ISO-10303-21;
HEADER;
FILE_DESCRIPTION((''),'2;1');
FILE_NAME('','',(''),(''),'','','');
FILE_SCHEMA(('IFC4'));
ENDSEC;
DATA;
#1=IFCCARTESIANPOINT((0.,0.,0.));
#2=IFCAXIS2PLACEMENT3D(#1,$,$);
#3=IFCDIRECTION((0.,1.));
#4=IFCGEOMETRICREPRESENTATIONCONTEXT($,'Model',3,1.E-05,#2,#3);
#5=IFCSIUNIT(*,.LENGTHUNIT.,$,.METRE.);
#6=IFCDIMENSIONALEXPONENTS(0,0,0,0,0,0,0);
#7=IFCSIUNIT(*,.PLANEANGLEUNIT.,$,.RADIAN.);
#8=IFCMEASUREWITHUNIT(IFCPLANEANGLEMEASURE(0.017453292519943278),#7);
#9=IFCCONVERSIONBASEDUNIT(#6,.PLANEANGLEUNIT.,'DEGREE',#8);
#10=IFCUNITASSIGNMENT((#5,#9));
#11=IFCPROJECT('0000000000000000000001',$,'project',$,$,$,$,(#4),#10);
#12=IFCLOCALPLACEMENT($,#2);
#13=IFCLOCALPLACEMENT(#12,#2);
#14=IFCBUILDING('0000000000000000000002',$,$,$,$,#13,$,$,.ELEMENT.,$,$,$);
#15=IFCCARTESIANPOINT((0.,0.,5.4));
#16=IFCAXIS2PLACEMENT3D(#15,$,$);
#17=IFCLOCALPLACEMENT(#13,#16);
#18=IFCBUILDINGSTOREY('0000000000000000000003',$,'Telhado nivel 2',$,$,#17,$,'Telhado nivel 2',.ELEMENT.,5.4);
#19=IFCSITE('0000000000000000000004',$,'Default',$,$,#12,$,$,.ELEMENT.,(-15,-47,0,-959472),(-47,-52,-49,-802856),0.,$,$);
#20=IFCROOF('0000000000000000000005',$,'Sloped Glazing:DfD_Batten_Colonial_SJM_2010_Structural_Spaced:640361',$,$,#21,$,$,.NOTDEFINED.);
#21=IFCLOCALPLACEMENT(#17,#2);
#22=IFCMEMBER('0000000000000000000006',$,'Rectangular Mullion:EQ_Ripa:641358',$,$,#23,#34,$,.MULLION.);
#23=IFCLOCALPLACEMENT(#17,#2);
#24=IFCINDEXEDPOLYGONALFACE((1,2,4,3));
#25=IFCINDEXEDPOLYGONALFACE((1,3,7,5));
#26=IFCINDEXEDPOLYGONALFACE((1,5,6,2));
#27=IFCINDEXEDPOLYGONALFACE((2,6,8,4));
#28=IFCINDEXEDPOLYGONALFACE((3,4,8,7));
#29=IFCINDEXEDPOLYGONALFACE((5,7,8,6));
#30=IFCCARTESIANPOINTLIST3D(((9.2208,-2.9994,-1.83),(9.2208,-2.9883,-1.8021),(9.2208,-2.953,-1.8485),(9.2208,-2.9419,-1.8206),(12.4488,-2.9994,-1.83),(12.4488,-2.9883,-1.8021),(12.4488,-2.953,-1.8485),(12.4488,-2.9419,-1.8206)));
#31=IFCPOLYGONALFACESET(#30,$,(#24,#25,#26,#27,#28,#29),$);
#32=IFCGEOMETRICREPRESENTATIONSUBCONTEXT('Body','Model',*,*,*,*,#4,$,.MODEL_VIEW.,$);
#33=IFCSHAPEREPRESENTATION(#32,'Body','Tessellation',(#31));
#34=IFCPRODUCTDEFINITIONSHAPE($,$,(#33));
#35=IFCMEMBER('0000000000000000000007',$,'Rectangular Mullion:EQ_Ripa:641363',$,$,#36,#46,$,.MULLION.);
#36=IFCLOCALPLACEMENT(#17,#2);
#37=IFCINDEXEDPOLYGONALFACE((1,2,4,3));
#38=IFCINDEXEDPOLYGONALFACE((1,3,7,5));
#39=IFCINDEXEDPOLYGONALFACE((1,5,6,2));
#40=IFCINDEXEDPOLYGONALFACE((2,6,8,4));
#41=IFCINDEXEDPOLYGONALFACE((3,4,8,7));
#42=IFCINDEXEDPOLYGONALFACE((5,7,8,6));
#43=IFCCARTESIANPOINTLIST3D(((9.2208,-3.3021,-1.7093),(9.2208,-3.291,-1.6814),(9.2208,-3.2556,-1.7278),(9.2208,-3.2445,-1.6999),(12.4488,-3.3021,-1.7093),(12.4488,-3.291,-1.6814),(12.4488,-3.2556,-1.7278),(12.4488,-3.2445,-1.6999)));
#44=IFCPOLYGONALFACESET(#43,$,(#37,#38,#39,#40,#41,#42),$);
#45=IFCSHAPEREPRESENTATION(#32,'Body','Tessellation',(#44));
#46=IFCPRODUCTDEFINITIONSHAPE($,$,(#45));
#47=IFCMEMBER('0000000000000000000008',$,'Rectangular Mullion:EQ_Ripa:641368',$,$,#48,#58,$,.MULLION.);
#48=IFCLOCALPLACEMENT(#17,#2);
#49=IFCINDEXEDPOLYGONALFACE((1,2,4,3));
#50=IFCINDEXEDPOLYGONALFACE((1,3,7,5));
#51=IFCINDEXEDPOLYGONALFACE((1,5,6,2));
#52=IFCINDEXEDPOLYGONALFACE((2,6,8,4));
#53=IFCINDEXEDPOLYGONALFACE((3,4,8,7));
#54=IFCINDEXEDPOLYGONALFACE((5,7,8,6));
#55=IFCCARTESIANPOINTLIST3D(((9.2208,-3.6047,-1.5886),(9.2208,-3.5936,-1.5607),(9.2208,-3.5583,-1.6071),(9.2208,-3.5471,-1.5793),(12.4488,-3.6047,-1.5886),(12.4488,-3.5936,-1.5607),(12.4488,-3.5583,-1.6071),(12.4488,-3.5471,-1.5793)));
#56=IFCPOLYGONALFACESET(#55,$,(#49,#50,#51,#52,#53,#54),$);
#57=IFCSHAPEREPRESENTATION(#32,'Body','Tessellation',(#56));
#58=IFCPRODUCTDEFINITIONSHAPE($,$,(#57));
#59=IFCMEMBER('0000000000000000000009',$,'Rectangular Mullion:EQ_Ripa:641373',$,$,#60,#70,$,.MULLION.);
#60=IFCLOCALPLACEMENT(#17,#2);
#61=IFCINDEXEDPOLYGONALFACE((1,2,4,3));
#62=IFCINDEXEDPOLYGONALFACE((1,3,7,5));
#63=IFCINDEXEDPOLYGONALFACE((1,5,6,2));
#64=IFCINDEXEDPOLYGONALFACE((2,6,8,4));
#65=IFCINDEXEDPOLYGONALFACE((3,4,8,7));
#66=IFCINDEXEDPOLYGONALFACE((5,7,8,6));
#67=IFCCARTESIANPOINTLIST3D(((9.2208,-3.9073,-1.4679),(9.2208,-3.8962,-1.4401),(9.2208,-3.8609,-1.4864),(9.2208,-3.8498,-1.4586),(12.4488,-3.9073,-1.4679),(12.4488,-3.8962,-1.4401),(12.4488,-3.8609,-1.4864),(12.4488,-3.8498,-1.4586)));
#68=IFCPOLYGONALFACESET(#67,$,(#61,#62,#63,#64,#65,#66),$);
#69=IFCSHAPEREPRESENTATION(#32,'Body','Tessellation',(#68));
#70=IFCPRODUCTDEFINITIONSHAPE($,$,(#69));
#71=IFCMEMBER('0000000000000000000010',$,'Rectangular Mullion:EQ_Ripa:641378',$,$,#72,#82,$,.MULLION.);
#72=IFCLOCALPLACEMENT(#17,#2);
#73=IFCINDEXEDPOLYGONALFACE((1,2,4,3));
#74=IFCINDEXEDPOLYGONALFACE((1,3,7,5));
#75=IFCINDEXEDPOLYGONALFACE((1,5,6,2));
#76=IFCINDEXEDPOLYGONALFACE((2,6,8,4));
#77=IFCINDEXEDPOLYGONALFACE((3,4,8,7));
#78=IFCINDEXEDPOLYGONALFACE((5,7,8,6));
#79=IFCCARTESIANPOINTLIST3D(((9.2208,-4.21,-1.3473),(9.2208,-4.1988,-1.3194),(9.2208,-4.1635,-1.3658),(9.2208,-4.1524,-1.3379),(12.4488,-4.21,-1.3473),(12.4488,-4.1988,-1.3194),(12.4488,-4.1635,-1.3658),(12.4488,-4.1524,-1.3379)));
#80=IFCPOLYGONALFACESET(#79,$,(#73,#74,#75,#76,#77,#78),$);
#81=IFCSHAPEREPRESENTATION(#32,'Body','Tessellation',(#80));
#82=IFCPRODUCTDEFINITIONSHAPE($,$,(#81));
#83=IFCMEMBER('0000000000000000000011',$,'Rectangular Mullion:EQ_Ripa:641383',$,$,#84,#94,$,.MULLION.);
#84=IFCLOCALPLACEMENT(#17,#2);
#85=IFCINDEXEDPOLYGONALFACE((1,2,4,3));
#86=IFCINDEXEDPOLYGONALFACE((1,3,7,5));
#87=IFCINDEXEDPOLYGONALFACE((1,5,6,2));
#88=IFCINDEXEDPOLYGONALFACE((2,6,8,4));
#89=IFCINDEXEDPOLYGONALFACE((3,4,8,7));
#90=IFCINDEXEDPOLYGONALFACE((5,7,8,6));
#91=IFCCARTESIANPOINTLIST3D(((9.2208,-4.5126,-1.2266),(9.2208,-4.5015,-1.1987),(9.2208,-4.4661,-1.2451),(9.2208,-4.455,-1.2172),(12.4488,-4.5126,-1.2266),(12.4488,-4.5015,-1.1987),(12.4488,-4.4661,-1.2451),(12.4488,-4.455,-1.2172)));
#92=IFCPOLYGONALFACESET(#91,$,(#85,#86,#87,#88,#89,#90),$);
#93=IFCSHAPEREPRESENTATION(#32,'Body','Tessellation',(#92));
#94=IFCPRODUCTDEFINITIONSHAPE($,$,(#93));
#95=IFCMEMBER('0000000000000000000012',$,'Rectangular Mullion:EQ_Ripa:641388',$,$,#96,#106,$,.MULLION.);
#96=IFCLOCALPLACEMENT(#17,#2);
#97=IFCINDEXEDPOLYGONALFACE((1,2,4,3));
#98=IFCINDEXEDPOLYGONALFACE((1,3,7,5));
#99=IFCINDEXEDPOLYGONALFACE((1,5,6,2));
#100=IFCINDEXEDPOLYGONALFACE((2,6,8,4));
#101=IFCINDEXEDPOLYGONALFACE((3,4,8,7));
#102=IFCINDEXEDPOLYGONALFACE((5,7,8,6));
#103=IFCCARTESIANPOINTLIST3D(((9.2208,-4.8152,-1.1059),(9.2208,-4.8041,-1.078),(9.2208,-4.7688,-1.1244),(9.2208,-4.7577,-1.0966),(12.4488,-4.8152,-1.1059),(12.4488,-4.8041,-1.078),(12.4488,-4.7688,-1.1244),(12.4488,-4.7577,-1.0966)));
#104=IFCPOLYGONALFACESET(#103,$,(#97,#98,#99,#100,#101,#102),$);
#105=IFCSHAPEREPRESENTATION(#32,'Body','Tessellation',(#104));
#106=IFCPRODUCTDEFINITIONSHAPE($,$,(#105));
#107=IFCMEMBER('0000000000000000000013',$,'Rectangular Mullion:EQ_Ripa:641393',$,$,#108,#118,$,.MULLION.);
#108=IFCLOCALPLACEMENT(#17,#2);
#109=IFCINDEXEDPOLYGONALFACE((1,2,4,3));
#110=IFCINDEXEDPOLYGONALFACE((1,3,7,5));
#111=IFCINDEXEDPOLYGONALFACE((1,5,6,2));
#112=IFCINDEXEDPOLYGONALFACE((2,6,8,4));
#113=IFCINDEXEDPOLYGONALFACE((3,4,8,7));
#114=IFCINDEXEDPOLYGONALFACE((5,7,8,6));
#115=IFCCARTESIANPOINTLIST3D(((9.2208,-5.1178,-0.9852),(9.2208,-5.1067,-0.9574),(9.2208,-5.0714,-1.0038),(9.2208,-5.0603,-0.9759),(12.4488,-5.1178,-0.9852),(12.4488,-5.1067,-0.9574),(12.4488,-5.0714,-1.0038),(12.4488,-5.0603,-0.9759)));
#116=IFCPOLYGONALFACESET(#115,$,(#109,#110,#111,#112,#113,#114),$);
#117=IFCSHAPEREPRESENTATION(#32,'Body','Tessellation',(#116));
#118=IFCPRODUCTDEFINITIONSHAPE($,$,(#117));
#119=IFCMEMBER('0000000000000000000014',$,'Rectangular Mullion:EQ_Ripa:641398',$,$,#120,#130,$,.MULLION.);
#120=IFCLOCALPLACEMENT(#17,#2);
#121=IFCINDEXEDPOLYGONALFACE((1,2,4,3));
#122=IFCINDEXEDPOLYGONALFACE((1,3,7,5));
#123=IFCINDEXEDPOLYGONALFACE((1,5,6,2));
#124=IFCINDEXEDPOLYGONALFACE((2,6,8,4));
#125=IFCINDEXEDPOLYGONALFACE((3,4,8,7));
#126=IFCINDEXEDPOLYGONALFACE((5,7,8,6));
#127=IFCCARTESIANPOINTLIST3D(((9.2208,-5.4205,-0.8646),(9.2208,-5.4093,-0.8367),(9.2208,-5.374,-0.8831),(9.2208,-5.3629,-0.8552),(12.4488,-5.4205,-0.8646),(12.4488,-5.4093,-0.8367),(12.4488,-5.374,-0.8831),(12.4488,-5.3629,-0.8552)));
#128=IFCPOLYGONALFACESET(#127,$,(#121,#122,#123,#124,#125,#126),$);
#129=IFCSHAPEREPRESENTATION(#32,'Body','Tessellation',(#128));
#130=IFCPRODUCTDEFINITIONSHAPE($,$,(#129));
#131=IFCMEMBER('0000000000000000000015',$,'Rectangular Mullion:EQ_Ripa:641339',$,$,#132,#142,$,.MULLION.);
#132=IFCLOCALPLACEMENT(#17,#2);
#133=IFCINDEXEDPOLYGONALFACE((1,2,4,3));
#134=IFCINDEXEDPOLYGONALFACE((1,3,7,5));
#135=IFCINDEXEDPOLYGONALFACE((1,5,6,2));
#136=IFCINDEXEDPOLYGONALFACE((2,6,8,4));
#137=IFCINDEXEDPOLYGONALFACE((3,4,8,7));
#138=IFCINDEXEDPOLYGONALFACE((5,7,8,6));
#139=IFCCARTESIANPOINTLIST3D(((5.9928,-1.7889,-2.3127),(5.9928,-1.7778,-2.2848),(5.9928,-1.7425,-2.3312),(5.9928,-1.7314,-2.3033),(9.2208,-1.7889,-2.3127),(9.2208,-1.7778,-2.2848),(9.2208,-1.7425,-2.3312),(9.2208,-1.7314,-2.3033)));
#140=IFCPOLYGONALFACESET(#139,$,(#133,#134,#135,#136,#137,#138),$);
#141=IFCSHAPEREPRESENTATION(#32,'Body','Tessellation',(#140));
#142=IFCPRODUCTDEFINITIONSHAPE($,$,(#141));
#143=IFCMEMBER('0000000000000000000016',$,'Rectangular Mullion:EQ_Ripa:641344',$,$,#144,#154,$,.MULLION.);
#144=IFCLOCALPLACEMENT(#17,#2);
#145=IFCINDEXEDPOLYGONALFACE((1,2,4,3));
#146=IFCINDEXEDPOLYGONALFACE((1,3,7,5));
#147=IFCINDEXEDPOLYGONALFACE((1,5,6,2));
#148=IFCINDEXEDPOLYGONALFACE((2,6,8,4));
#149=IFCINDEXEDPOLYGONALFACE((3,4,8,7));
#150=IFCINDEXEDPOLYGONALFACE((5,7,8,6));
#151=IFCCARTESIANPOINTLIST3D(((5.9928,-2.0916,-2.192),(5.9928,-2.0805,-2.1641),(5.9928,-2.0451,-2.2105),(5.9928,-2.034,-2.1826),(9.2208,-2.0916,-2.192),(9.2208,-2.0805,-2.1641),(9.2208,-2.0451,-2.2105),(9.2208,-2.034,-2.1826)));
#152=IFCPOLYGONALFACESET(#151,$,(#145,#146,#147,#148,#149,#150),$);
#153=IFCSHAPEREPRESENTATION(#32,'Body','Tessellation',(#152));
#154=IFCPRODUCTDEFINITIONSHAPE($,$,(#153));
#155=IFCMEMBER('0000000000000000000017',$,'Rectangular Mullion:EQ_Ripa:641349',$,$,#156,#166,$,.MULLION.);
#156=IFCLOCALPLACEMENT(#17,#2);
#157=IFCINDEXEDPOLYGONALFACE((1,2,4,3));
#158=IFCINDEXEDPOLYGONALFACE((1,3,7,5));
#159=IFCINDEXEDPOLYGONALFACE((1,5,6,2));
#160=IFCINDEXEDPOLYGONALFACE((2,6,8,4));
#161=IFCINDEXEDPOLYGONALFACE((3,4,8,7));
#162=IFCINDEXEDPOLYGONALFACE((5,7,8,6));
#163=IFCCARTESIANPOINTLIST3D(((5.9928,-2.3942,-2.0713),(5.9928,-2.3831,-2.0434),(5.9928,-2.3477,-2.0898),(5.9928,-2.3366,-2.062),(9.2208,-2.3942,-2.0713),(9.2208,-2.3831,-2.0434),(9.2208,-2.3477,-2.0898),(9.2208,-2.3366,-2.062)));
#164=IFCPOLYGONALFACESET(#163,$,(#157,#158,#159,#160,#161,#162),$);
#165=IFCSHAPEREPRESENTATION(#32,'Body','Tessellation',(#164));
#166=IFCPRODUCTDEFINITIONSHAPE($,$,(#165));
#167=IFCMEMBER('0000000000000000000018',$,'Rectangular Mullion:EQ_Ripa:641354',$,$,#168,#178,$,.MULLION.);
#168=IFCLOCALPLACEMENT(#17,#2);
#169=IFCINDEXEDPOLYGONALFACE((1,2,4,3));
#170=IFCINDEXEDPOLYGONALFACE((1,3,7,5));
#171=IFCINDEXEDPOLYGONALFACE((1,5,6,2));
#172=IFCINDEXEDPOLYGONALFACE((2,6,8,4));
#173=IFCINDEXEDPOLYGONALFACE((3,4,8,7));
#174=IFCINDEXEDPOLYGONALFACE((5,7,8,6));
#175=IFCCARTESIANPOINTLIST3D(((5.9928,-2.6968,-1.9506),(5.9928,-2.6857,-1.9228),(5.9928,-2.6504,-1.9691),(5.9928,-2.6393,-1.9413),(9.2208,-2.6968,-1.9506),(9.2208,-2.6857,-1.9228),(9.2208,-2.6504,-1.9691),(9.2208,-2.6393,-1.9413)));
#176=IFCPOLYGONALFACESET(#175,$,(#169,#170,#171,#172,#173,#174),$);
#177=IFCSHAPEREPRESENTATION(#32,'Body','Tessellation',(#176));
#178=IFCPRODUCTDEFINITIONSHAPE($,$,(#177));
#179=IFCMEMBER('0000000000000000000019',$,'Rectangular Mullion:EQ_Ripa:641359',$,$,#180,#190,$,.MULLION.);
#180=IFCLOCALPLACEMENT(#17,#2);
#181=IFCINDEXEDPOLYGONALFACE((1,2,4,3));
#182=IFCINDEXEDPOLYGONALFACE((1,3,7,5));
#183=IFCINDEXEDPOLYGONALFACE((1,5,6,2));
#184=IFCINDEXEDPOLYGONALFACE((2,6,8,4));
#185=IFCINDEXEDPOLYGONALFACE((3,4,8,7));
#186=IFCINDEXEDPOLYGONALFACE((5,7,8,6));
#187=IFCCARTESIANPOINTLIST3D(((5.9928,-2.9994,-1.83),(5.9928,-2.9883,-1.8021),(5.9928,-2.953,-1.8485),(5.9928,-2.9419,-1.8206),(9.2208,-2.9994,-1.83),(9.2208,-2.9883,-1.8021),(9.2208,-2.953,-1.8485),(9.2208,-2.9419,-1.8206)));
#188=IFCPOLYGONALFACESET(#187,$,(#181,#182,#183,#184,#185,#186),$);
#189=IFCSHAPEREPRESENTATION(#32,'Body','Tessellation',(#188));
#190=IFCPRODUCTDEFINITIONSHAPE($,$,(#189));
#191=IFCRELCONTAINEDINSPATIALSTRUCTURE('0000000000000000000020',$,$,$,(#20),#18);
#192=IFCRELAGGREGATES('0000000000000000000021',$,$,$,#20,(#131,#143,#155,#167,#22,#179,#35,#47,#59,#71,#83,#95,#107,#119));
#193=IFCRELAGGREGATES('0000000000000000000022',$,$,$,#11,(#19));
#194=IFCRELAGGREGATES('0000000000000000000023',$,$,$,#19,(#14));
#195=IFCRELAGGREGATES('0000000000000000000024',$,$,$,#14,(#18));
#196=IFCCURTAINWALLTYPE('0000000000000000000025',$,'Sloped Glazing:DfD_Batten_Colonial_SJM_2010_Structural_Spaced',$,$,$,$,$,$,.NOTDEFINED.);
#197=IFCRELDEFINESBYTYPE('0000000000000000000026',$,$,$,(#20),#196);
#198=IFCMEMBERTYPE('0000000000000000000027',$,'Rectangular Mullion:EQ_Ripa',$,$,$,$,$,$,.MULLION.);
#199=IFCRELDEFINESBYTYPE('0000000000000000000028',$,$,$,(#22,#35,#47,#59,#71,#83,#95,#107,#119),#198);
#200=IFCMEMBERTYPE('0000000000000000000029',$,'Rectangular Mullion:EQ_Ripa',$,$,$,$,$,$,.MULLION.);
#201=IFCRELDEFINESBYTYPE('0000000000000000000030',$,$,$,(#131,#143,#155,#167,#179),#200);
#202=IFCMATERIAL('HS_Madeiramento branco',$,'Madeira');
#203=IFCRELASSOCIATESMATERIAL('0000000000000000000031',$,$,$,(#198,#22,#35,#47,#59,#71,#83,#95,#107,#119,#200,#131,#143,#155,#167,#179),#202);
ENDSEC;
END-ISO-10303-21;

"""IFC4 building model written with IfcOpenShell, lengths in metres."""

from ifc_helpers import new_model, entity, si_unit, converted_unit, direction, frame, origin, place, context, subcontext, project, spatial, indexed_curve, outline, extrude, source, transform, mapped, material, type_object, type_shapes, element, aggregate, save


model = new_model("IFC4")

# Units and contexts
model_context = context("Model", 3, precision=1e-05, world=origin(), true_north=direction((0.0, 1.0)))
body_context = subcontext(model_context, "Body", "Model", "MODEL_VIEW")
ifc_project = project(units=[si_unit("LENGTHUNIT", "METRE"), converted_unit("PLANEANGLEUNIT", "DEGREE", entity("IfcPlaneAngleMeasure", 0.017453292519943278), si_unit("PLANEANGLEUNIT", "RADIAN"), dimensions=[0, 0, 0, 0, 0, 0, 0])], contexts=[model_context])

# Site, building, storey
site_placement = place(None, origin())
site = spatial("IfcSite", under=ifc_project, at=site_placement, Name="Default", CompositionType="ELEMENT", RefLatitude=(-15, -47, 0, -959472), RefLongitude=(-47, -52, -49, -802856), RefElevation=0.0)
building_placement = place(site_placement, origin())
building = spatial("IfcBuilding", under=site, at=building_placement, CompositionType="ELEMENT")
storey_placement = place(building_placement, frame((0.0, 0.0, 5.4)))
storey = spatial("IfcBuildingStorey", under=building, at=storey_placement, Name="Telhado nivel 2", LongName="Telhado nivel 2", CompositionType="ELEMENT", Elevation=5.4)

# Roof, members
ifc_material = material(Name="HS_Madeiramento branco", Category="Madeira")
curtain_wall_type_1 = type_object("IfcCurtainWallType", Name="Sloped Glazing:DfD_Batten_Colonial_SJM_2010_Structural_Spaced", PredefinedType="NOTDEFINED")
roof_1_placement = place(storey_placement, frame((0.0, 0.0, -5.4)))
roof_1 = element("IfcRoof", 1, at=roof_1_placement, inside=storey, type_object=curtain_wall_type_1, Name="Sloped Glazing:DfD_Batten_Colonial_SJM_2010_Structural_Spaced:640361", PredefinedType="NOTDEFINED")
member_type_1 = type_object("IfcMemberType", Name="Rectangular Mullion:EQ_Ripa", PredefinedType="MULLION", material=ifc_material)
shared_shape_1 = source(origin(), body_context, "Body", "SweptSolid", [
    extrude(outline(indexed_curve([(-0.025, -0.015), (0.025, -0.015), (0.025, 0.015), (-0.025, 0.015), (-0.025, -0.015)], self_intersect=False)), frame((0.0, 0.0, -3.228), z_axis=(0.0, 0.0, 1.0), x_axis=(-1.0, 0.0, 0.0)), (0.0, 0.0, 1.0), 3.228),
])
type_shapes(member_type_1, [shared_shape_1])
member_1_placement = place(roof_1_placement, frame((12.4488, -2.9707, 3.5747), z_axis=(1.0, 0.0, 0.0), x_axis=(0.0, -0.928874, 0.370395)))
member_1 = element("IfcMember", 2, at=member_1_placement, type_object=member_type_1, material=ifc_material, Name="Rectangular Mullion:EQ_Ripa:641358", PredefinedType="MULLION", context=body_context, shape_type="MappedRepresentation", body=[
    mapped(shared_shape_1, transform((0.0, 0.0, 0.0), scale=1.0)),
])
member_2_placement = place(roof_1_placement, frame((12.4488, -3.2733, 3.6954), z_axis=(1.0, 0.0, 0.0), x_axis=(0.0, -0.928874, 0.370395)))
member_2 = element("IfcMember", 3, at=member_2_placement, type_object=member_type_1, material=ifc_material, Name="Rectangular Mullion:EQ_Ripa:641363", PredefinedType="MULLION", context=body_context, shape_type="MappedRepresentation", body=[
    mapped(shared_shape_1, transform((0.0, 0.0, 0.0), scale=1.0)),
])
member_3_placement = place(roof_1_placement, frame((12.4488, -3.5759, 3.8161), z_axis=(1.0, 0.0, 0.0), x_axis=(0.0, -0.928874, 0.370395)))
member_3 = element("IfcMember", 4, at=member_3_placement, type_object=member_type_1, material=ifc_material, Name="Rectangular Mullion:EQ_Ripa:641368", PredefinedType="MULLION", context=body_context, shape_type="MappedRepresentation", body=[
    mapped(shared_shape_1, transform((0.0, 0.0, 0.0), scale=1.0)),
])
member_4_placement = place(roof_1_placement, frame((12.4488, -3.8785, 3.9367), z_axis=(1.0, 0.0, 0.0), x_axis=(0.0, -0.928874, 0.370395)))
member_4 = element("IfcMember", 5, at=member_4_placement, type_object=member_type_1, material=ifc_material, Name="Rectangular Mullion:EQ_Ripa:641373", PredefinedType="MULLION", context=body_context, shape_type="MappedRepresentation", body=[
    mapped(shared_shape_1, transform((0.0, 0.0, 0.0), scale=1.0)),
])
member_5_placement = place(roof_1_placement, frame((12.4488, -4.1812, 4.0574), z_axis=(1.0, 0.0, 0.0), x_axis=(0.0, -0.928874, 0.370395)))
member_5 = element("IfcMember", 6, at=member_5_placement, type_object=member_type_1, material=ifc_material, Name="Rectangular Mullion:EQ_Ripa:641378", PredefinedType="MULLION", context=body_context, shape_type="MappedRepresentation", body=[
    mapped(shared_shape_1, transform((0.0, 0.0, 0.0), scale=1.0)),
])
member_6_placement = place(roof_1_placement, frame((12.4488, -4.4838, 4.1781), z_axis=(1.0, 0.0, 0.0), x_axis=(0.0, -0.928874, 0.370395)))
member_6 = element("IfcMember", 7, at=member_6_placement, type_object=member_type_1, material=ifc_material, Name="Rectangular Mullion:EQ_Ripa:641383", PredefinedType="MULLION", context=body_context, shape_type="MappedRepresentation", body=[
    mapped(shared_shape_1, transform((0.0, 0.0, 0.0), scale=1.0)),
])
member_7_placement = place(roof_1_placement, frame((12.4488, -4.7864, 4.2988), z_axis=(1.0, 0.0, 0.0), x_axis=(0.0, -0.928874, 0.370395)))
member_7 = element("IfcMember", 8, at=member_7_placement, type_object=member_type_1, material=ifc_material, Name="Rectangular Mullion:EQ_Ripa:641388", PredefinedType="MULLION", context=body_context, shape_type="MappedRepresentation", body=[
    mapped(shared_shape_1, transform((0.0, 0.0, 0.0), scale=1.0)),
])
member_8_placement = place(roof_1_placement, frame((12.4488, -5.0891, 4.4194), z_axis=(1.0, 0.0, 0.0), x_axis=(0.0, -0.928874, 0.370395)))
member_8 = element("IfcMember", 9, at=member_8_placement, type_object=member_type_1, material=ifc_material, Name="Rectangular Mullion:EQ_Ripa:641393", PredefinedType="MULLION", context=body_context, shape_type="MappedRepresentation", body=[
    mapped(shared_shape_1, transform((0.0, 0.0, 0.0), scale=1.0)),
])
member_9_placement = place(roof_1_placement, frame((12.4488, -5.3917, 4.5401), z_axis=(1.0, 0.0, 0.0), x_axis=(0.0, -0.928874, 0.370395)))
member_9 = element("IfcMember", 10, at=member_9_placement, type_object=member_type_1, material=ifc_material, Name="Rectangular Mullion:EQ_Ripa:641398", PredefinedType="MULLION", context=body_context, shape_type="MappedRepresentation", body=[
    mapped(shared_shape_1, transform((0.0, 0.0, 0.0), scale=1.0)),
])
member_type_2 = type_object("IfcMemberType", Name="Rectangular Mullion:EQ_Ripa", PredefinedType="MULLION", material=ifc_material)
shared_shape_2 = source(origin(), body_context, "Body", "SweptSolid", [
    extrude(outline(indexed_curve([(-0.025, -0.015), (0.025, -0.015), (0.025, 0.015), (-0.025, 0.015), (-0.025, -0.015)], self_intersect=False)), frame((0.0, 0.0, -3.228), z_axis=(0.0, 0.0, 1.0), x_axis=(-1.0, 0.0, 0.0)), (0.0, 0.0, 1.0), 3.228),
])
type_shapes(member_type_2, [shared_shape_2])
member_10_placement = place(roof_1_placement, frame((9.2208, -1.7602, 3.092), z_axis=(1.0, 0.0, 0.0), x_axis=(0.0, -0.928874, 0.370395)))
member_10 = element("IfcMember", 11, at=member_10_placement, type_object=member_type_2, material=ifc_material, Name="Rectangular Mullion:EQ_Ripa:641339", PredefinedType="MULLION", context=body_context, shape_type="MappedRepresentation", body=[
    mapped(shared_shape_2, transform((0.0, 0.0, 0.0), scale=1.0)),
])
member_11_placement = place(roof_1_placement, frame((9.2208, -2.0628, 3.2127), z_axis=(1.0, 0.0, 0.0), x_axis=(0.0, -0.928874, 0.370395)))
member_11 = element("IfcMember", 12, at=member_11_placement, type_object=member_type_2, material=ifc_material, Name="Rectangular Mullion:EQ_Ripa:641344", PredefinedType="MULLION", context=body_context, shape_type="MappedRepresentation", body=[
    mapped(shared_shape_2, transform((0.0, 0.0, 0.0), scale=1.0)),
])
member_12_placement = place(roof_1_placement, frame((9.2208, -2.3654, 3.3334), z_axis=(1.0, 0.0, 0.0), x_axis=(0.0, -0.928874, 0.370395)))
member_12 = element("IfcMember", 13, at=member_12_placement, type_object=member_type_2, material=ifc_material, Name="Rectangular Mullion:EQ_Ripa:641349", PredefinedType="MULLION", context=body_context, shape_type="MappedRepresentation", body=[
    mapped(shared_shape_2, transform((0.0, 0.0, 0.0), scale=1.0)),
])
member_13_placement = place(roof_1_placement, frame((9.2208, -2.668, 3.454), z_axis=(1.0, 0.0, 0.0), x_axis=(0.0, -0.928874, 0.370395)))
member_13 = element("IfcMember", 14, at=member_13_placement, type_object=member_type_2, material=ifc_material, Name="Rectangular Mullion:EQ_Ripa:641354", PredefinedType="MULLION", context=body_context, shape_type="MappedRepresentation", body=[
    mapped(shared_shape_2, transform((0.0, 0.0, 0.0), scale=1.0)),
])
member_14_placement = place(roof_1_placement, frame((9.2208, -2.9707, 3.5747), z_axis=(1.0, 0.0, 0.0), x_axis=(0.0, -0.928874, 0.370395)))
member_14 = element("IfcMember", 15, at=member_14_placement, type_object=member_type_2, material=ifc_material, Name="Rectangular Mullion:EQ_Ripa:641359", PredefinedType="MULLION", context=body_context, shape_type="MappedRepresentation", body=[
    mapped(shared_shape_2, transform((0.0, 0.0, 0.0), scale=1.0)),
])
aggregate(roof_1, [member_10, member_11, member_12, member_13, member_1, member_14, member_2, member_3, member_4, member_5, member_6, member_7, member_8, member_9])

save(model, "model.ifc")
